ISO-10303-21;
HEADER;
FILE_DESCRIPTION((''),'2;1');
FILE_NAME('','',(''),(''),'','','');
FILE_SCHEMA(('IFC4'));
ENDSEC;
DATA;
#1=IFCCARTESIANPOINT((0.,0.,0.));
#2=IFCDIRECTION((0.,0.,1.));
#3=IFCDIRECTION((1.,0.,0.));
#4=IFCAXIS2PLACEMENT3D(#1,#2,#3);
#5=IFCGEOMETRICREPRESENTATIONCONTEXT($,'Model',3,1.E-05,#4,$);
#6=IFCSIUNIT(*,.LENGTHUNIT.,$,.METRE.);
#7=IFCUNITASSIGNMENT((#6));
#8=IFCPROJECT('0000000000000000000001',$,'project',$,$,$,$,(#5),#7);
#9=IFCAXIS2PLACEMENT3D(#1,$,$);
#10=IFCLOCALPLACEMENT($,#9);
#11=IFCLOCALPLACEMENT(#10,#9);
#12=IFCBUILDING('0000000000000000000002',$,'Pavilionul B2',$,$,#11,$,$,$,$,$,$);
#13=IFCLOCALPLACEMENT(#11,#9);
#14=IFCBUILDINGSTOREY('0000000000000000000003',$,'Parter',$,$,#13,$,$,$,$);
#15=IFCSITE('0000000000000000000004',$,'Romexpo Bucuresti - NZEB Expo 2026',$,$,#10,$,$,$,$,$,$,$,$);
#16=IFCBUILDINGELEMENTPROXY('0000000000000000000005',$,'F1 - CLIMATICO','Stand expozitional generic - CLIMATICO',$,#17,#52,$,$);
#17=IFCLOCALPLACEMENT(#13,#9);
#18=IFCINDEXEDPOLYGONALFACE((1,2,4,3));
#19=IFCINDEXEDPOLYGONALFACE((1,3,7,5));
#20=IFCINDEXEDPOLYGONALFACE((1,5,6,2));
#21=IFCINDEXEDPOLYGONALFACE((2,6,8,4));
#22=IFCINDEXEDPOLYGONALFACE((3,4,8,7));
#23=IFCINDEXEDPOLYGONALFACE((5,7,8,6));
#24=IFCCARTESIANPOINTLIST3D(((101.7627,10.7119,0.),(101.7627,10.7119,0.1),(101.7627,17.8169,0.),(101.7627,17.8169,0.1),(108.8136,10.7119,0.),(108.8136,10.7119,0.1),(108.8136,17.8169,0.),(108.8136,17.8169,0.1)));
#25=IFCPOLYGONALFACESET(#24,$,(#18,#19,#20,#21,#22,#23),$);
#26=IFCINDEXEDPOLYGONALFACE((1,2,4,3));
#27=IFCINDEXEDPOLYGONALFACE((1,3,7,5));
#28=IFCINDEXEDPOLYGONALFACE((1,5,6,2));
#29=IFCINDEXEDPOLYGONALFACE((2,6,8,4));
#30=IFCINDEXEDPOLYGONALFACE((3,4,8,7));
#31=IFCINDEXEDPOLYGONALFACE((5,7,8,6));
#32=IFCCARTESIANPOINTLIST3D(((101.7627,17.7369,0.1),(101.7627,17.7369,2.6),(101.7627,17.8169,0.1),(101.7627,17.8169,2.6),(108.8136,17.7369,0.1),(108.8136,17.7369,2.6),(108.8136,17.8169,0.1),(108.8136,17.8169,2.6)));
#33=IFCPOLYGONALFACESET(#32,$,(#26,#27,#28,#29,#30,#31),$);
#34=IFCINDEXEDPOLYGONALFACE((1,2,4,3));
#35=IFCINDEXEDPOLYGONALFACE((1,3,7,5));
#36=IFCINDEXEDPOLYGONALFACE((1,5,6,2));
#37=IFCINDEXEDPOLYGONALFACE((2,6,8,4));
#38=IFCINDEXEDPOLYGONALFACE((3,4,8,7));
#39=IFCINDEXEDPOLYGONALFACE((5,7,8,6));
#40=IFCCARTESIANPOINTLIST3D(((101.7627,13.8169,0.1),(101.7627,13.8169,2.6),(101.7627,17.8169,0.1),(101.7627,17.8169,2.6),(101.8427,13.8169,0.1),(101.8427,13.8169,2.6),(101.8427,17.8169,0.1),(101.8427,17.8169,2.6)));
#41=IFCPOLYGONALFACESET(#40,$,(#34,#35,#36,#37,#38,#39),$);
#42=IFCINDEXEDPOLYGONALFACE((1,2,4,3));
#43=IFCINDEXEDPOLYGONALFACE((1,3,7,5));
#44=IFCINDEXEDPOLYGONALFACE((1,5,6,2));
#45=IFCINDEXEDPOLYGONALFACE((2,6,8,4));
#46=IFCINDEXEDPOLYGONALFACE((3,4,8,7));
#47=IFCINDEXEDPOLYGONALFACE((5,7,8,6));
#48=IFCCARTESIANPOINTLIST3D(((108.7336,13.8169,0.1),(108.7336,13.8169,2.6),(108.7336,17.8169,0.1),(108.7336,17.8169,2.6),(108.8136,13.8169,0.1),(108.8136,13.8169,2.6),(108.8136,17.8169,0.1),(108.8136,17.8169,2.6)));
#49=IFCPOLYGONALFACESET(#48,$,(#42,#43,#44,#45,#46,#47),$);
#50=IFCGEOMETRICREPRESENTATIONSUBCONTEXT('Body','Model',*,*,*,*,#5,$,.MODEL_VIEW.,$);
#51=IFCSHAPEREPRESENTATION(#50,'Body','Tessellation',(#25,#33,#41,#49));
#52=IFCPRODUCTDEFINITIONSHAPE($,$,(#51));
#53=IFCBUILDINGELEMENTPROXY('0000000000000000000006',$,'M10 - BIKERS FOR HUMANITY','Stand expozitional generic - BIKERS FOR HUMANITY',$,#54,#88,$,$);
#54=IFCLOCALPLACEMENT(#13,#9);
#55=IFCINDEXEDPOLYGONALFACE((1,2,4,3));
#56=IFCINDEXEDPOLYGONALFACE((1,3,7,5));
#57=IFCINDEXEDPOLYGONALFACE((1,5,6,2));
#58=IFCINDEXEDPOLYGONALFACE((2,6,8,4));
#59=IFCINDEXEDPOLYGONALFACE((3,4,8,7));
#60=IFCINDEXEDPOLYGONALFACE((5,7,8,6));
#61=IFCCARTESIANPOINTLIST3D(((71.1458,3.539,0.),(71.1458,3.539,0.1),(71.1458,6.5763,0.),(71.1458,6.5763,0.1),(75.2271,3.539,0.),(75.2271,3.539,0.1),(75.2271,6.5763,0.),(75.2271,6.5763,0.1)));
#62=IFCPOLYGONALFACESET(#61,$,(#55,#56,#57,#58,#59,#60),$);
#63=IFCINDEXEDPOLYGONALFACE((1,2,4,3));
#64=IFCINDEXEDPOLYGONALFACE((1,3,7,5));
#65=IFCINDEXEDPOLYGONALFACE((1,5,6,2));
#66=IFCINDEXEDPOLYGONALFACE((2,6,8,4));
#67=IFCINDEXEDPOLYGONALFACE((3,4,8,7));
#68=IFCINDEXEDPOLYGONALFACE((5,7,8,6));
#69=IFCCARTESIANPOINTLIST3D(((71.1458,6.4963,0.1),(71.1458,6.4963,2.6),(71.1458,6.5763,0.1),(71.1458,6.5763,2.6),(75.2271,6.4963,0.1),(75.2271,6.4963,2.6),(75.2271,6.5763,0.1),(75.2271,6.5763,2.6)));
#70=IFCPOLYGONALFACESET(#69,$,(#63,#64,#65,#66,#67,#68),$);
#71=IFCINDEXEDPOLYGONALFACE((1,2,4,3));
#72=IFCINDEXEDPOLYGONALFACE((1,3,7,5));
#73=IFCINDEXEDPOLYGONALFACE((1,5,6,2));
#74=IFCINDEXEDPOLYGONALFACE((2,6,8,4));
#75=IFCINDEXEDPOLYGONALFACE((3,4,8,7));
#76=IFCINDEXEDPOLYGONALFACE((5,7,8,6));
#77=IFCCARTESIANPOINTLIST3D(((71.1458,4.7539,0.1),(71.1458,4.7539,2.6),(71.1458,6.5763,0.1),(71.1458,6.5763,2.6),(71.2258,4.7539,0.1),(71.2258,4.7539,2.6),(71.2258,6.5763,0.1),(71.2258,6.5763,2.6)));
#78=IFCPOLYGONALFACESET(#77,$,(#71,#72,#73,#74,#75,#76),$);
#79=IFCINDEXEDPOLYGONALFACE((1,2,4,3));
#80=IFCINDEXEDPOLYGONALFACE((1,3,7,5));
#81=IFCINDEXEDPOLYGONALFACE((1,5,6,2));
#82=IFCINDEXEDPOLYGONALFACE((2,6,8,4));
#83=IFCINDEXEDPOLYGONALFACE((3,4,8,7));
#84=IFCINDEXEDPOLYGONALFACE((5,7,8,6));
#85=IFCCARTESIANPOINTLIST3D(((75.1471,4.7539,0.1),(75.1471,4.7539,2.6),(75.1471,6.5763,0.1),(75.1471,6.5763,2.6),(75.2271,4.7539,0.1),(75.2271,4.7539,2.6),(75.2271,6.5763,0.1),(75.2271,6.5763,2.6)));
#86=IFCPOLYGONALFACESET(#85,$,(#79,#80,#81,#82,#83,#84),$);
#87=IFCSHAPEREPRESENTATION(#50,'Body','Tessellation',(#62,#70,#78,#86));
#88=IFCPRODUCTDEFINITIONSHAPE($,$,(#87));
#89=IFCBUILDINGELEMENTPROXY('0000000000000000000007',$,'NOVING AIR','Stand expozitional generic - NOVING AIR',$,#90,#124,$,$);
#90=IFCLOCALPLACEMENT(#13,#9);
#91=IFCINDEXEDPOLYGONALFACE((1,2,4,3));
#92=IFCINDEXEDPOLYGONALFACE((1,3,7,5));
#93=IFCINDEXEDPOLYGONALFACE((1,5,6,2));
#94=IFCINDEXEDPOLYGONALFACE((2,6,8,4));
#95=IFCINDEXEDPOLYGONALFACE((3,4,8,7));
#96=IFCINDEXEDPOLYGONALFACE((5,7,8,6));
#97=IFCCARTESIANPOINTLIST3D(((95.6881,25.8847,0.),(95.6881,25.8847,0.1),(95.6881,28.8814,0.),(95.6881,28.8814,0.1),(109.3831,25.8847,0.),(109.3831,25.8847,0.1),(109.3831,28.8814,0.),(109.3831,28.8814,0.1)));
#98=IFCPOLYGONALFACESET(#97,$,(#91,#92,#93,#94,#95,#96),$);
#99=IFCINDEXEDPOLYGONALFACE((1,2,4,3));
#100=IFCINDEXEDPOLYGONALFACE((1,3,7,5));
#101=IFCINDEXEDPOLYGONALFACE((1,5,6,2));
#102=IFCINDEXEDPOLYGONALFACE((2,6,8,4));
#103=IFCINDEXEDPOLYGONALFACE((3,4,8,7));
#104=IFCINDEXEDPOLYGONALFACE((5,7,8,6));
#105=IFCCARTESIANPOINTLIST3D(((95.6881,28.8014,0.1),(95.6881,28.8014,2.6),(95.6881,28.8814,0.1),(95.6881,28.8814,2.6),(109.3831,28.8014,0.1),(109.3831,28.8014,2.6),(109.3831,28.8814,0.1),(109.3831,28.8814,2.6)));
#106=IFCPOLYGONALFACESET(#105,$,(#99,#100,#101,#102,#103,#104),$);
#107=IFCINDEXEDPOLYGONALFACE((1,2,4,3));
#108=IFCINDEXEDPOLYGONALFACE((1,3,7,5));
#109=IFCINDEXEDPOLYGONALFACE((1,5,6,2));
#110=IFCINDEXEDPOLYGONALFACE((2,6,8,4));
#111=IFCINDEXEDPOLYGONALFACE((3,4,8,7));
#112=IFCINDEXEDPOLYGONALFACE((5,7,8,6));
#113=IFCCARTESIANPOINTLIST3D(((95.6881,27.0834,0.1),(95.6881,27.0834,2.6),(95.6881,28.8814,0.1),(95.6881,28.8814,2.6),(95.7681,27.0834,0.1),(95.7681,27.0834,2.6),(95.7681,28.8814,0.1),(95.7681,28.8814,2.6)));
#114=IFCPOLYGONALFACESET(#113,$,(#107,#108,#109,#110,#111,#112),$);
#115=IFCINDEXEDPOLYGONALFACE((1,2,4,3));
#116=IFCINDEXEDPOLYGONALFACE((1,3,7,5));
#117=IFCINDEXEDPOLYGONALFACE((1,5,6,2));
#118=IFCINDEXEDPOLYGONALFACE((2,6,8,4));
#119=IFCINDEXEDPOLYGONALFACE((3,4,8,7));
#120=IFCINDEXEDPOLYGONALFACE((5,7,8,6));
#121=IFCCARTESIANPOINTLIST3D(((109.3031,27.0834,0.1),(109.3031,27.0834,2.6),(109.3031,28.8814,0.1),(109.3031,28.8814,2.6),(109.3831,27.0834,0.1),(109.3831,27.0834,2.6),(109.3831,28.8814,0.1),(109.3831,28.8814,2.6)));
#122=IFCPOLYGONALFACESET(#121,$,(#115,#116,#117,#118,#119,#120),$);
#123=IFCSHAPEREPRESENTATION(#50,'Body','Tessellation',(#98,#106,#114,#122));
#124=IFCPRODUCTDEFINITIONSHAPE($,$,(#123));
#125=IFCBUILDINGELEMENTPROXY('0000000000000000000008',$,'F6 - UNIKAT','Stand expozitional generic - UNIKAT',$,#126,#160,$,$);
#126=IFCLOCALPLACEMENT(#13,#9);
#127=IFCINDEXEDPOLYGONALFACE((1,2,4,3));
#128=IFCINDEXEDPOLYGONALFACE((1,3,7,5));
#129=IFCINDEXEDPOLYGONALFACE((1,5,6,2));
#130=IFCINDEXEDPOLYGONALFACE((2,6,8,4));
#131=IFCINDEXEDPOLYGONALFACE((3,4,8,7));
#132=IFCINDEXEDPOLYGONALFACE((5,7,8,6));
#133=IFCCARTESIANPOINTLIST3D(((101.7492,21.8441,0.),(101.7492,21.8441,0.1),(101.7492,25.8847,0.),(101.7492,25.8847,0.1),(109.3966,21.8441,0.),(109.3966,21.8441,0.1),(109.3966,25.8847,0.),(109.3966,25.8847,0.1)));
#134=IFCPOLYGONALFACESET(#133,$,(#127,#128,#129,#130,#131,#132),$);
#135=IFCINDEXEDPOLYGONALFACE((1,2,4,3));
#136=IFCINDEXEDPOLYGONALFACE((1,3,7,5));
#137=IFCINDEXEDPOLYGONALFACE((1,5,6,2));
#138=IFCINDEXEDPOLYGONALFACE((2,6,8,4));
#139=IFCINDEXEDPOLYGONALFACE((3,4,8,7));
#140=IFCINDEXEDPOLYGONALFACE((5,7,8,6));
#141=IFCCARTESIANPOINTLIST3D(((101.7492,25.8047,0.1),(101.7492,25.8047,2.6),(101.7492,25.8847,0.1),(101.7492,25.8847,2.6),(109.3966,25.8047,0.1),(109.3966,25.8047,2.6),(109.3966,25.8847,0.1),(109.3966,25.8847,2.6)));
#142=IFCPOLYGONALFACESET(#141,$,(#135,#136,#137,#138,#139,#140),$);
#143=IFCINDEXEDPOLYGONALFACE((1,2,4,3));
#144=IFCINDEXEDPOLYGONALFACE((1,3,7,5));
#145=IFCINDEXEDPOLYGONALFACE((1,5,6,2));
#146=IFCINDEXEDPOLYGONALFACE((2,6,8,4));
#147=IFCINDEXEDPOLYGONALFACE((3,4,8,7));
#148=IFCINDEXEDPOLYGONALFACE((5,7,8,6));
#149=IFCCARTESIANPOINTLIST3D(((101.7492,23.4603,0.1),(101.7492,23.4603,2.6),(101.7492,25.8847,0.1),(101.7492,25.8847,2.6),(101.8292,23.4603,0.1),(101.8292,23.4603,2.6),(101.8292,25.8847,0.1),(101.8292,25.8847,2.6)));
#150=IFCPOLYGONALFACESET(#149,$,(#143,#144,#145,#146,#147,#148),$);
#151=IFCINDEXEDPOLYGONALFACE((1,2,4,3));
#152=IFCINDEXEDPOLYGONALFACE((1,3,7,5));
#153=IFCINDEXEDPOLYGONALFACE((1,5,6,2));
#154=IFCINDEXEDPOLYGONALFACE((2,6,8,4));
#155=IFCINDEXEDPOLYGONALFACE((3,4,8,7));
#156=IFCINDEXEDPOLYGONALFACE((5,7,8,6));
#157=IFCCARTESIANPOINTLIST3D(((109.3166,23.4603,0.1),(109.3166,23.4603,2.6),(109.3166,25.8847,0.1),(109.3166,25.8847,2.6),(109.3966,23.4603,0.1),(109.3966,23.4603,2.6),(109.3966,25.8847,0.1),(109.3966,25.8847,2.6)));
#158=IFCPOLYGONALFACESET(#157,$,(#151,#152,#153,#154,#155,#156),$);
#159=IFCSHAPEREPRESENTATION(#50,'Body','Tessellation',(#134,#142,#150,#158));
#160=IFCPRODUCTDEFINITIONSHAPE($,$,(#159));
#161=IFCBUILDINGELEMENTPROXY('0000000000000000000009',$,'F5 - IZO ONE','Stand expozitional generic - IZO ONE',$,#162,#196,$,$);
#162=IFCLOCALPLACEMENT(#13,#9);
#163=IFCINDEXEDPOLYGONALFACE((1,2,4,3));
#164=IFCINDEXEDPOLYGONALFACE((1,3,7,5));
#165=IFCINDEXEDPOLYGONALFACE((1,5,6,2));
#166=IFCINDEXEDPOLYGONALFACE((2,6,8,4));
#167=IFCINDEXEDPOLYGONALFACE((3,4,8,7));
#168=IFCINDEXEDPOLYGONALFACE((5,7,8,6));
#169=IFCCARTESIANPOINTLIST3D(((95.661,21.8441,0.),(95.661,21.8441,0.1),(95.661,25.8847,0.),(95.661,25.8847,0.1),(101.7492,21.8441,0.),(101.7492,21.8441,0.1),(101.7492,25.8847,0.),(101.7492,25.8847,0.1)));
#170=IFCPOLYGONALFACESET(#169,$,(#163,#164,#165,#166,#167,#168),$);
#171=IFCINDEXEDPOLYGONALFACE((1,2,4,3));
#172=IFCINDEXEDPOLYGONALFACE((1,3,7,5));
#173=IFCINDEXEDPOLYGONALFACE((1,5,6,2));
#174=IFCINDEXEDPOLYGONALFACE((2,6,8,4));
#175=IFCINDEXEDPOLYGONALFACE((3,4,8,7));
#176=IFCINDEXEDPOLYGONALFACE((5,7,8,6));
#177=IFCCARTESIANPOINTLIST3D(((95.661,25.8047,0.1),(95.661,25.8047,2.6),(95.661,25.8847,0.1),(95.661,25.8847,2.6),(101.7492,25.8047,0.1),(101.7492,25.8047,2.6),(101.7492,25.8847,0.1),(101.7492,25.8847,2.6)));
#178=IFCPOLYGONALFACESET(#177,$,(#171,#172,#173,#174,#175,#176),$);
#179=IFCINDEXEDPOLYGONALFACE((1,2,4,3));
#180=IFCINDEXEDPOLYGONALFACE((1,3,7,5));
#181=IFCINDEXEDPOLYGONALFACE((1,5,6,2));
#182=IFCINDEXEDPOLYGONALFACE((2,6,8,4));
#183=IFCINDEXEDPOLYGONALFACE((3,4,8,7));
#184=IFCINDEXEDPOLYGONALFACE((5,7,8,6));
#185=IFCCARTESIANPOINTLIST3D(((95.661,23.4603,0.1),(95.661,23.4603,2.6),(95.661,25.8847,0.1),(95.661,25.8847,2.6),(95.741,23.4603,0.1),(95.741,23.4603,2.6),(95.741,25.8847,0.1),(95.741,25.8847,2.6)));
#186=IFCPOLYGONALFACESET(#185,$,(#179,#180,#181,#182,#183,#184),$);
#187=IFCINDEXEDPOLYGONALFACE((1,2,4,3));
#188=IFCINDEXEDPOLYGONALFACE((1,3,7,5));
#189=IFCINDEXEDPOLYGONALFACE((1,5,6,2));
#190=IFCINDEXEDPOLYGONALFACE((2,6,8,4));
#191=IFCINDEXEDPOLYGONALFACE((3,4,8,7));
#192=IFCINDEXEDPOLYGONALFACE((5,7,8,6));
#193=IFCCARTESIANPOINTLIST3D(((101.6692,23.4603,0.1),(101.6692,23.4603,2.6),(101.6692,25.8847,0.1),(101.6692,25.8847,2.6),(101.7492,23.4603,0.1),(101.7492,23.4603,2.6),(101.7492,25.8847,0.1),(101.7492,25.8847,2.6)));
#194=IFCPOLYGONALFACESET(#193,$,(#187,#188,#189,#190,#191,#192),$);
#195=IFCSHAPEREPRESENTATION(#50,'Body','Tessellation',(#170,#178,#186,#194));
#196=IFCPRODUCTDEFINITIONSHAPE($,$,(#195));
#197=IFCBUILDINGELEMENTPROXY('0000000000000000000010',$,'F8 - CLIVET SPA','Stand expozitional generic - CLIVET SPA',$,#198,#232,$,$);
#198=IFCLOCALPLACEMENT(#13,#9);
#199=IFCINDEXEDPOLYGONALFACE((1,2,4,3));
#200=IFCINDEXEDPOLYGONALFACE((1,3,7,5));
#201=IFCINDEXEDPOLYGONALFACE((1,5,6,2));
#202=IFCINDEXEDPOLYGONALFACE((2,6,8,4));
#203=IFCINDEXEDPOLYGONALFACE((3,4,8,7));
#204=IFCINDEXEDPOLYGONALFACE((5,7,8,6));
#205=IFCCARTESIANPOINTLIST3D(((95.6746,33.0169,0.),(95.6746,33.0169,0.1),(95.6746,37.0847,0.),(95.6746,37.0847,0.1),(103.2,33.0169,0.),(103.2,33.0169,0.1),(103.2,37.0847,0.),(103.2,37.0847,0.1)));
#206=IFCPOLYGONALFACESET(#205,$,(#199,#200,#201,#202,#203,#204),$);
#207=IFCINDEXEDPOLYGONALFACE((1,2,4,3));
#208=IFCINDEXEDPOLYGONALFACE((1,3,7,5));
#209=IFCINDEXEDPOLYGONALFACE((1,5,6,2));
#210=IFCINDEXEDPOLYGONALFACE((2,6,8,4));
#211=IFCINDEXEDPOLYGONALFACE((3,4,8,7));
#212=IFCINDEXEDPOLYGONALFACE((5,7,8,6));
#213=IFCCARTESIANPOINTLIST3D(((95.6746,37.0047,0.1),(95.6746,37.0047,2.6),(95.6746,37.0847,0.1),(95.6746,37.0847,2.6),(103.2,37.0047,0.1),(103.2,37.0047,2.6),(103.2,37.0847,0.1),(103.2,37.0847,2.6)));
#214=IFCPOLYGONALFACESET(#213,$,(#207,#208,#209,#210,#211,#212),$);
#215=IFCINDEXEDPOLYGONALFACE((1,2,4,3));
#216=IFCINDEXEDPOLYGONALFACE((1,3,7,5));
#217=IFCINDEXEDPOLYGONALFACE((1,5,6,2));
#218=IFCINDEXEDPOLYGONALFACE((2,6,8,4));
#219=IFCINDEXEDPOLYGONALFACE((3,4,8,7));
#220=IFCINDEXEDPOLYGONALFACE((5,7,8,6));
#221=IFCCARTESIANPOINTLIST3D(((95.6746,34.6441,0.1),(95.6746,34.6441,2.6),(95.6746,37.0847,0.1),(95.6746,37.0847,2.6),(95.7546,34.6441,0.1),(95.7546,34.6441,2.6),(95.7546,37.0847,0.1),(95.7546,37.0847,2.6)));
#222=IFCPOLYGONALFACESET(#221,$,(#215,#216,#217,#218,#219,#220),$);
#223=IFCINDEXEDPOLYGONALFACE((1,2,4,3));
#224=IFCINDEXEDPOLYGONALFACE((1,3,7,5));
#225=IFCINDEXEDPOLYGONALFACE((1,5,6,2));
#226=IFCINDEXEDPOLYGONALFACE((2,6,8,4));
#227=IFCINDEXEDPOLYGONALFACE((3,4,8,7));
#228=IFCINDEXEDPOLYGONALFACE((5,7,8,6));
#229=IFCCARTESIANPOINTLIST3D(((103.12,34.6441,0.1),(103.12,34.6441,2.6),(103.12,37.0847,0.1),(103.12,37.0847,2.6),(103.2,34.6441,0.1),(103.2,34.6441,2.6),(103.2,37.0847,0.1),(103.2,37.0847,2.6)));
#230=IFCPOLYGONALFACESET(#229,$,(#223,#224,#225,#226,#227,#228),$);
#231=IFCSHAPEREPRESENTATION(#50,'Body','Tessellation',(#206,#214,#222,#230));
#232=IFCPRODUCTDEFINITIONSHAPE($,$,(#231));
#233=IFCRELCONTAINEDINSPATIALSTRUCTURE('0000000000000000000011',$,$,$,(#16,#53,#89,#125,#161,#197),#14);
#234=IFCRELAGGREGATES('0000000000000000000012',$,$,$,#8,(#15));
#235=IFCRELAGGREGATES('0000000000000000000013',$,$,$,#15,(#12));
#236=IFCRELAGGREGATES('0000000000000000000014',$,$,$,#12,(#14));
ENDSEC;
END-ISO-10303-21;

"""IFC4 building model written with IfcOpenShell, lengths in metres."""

from ifc_helpers import new_model, si_unit, frame, frame_2d, origin, origin_with_axes, place, context, subcontext, project, spatial, rectangle, extrude, element, save


model = new_model("IFC4")

# Units and contexts
model_context = context("Model", 3, precision=1e-05, world=origin_with_axes())
body_context = subcontext(model_context, "Body", "Model", "MODEL_VIEW")
ifc_project = project(units=[si_unit("LENGTHUNIT", "METRE")], contexts=[model_context])

# Site, building, storey
site_placement = place(None, origin())
site = spatial("IfcSite", under=ifc_project, at=site_placement, Name="Romexpo Bucuresti - NZEB Expo 2026")
building_placement = place(site_placement, origin())
building = spatial("IfcBuilding", under=site, at=building_placement, Name="Pavilionul B2")
storey_placement = place(building_placement, origin())
storey = spatial("IfcBuildingStorey", under=building, at=storey_placement, Name="Parter")

# Building element proxies
proxy_1_placement = place(storey_placement, frame((101.7627, 10.7119, 0.0), z_axis=(0.0, 0.0, 1.0), x_axis=(1.0, 0.0, 0.0)))
element("IfcBuildingElementProxy", 1, at=proxy_1_placement, inside=storey, Name="F1 - CLIMATICO", Description="Stand expozitional generic - CLIMATICO", context=body_context, shape_type="SweptSolid", body=[
    extrude(rectangle(XDim=7.0508, YDim=7.1051, at=frame_2d((3.5254, 3.5525))), origin(), (0.0, 0.0, 1.0), 0.1),
    extrude(rectangle(XDim=7.0508, YDim=0.08, at=frame_2d((3.5254, 7.0651))), frame((0.0, 0.0, 0.1)), (0.0, 0.0, 1.0), 2.5),
    extrude(rectangle(XDim=0.08, YDim=4.0, at=frame_2d((0.04, 5.1051))), frame((0.0, 0.0, 0.1)), (0.0, 0.0, 1.0), 2.5),
    extrude(rectangle(XDim=0.08, YDim=4.0, at=frame_2d((7.0108, 5.1051))), frame((0.0, 0.0, 0.1)), (0.0, 0.0, 1.0), 2.5),
])
proxy_2_placement = place(storey_placement, frame((71.1458, 3.539, 0.0), z_axis=(0.0, 0.0, 1.0), x_axis=(1.0, 0.0, 0.0)))
element("IfcBuildingElementProxy", 2, at=proxy_2_placement, inside=storey, Name="M10 - BIKERS FOR HUMANITY", Description="Stand expozitional generic - BIKERS FOR HUMANITY", context=body_context, shape_type="SweptSolid", body=[
    extrude(rectangle(XDim=4.0814, YDim=3.0373, at=frame_2d((2.0407, 1.5186))), origin(), (0.0, 0.0, 1.0), 0.1),
    extrude(rectangle(XDim=4.0814, YDim=0.08, at=frame_2d((2.0407, 2.9973))), frame((0.0, 0.0, 0.1)), (0.0, 0.0, 1.0), 2.5),
    extrude(rectangle(XDim=0.08, YDim=1.8224, at=frame_2d((0.04, 2.1261))), frame((0.0, 0.0, 0.1)), (0.0, 0.0, 1.0), 2.5),
    extrude(rectangle(XDim=0.08, YDim=1.8224, at=frame_2d((4.0414, 2.1261))), frame((0.0, 0.0, 0.1)), (0.0, 0.0, 1.0), 2.5),
])
proxy_3_placement = place(storey_placement, frame((95.6881, 25.8847, 0.0), z_axis=(0.0, 0.0, 1.0), x_axis=(1.0, 0.0, 0.0)))
element("IfcBuildingElementProxy", 3, at=proxy_3_placement, inside=storey, Name="NOVING AIR", Description="Stand expozitional generic - NOVING AIR", context=body_context, shape_type="SweptSolid", body=[
    extrude(rectangle(XDim=13.6949, YDim=2.9966, at=frame_2d((6.8475, 1.4983))), origin(), (0.0, 0.0, 1.0), 0.1),
    extrude(rectangle(XDim=13.6949, YDim=0.08, at=frame_2d((6.8475, 2.9566))), frame((0.0, 0.0, 0.1)), (0.0, 0.0, 1.0), 2.5),
    extrude(rectangle(XDim=0.08, YDim=1.798, at=frame_2d((0.04, 2.0976))), frame((0.0, 0.0, 0.1)), (0.0, 0.0, 1.0), 2.5),
    extrude(rectangle(XDim=0.08, YDim=1.798, at=frame_2d((13.6549, 2.0976))), frame((0.0, 0.0, 0.1)), (0.0, 0.0, 1.0), 2.5),
])
proxy_4_placement = place(storey_placement, frame((101.7492, 21.8441, 0.0), z_axis=(0.0, 0.0, 1.0), x_axis=(1.0, 0.0, 0.0)))
element("IfcBuildingElementProxy", 4, at=proxy_4_placement, inside=storey, Name="F6 - UNIKAT", Description="Stand expozitional generic - UNIKAT", context=body_context, shape_type="SweptSolid", body=[
    extrude(rectangle(XDim=7.6475, YDim=4.0407, at=frame_2d((3.8237, 2.0203))), origin(), (0.0, 0.0, 1.0), 0.1),
    extrude(rectangle(XDim=7.6475, YDim=0.08, at=frame_2d((3.8237, 4.0007))), frame((0.0, 0.0, 0.1)), (0.0, 0.0, 1.0), 2.5),
    extrude(rectangle(XDim=0.08, YDim=2.4244, at=frame_2d((0.04, 2.8285))), frame((0.0, 0.0, 0.1)), (0.0, 0.0, 1.0), 2.5),
    extrude(rectangle(XDim=0.08, YDim=2.4244, at=frame_2d((7.6075, 2.8285))), frame((0.0, 0.0, 0.1)), (0.0, 0.0, 1.0), 2.5),
])
proxy_5_placement = place(storey_placement, frame((95.661, 21.8441, 0.0), z_axis=(0.0, 0.0, 1.0), x_axis=(1.0, 0.0, 0.0)))
element("IfcBuildingElementProxy", 5, at=proxy_5_placement, inside=storey, Name="F5 - IZO ONE", Description="Stand expozitional generic - IZO ONE", context=body_context, shape_type="SweptSolid", body=[
    extrude(rectangle(XDim=6.0881, YDim=4.0407, at=frame_2d((3.0441, 2.0203))), origin(), (0.0, 0.0, 1.0), 0.1),
    extrude(rectangle(XDim=6.0881, YDim=0.08, at=frame_2d((3.0441, 4.0007))), frame((0.0, 0.0, 0.1)), (0.0, 0.0, 1.0), 2.5),
    extrude(rectangle(XDim=0.08, YDim=2.4244, at=frame_2d((0.04, 2.8285))), frame((0.0, 0.0, 0.1)), (0.0, 0.0, 1.0), 2.5),
    extrude(rectangle(XDim=0.08, YDim=2.4244, at=frame_2d((6.0481, 2.8285))), frame((0.0, 0.0, 0.1)), (0.0, 0.0, 1.0), 2.5),
])
proxy_6_placement = place(storey_placement, frame((95.6746, 33.0169, 0.0), z_axis=(0.0, 0.0, 1.0), x_axis=(1.0, 0.0, 0.0)))
element("IfcBuildingElementProxy", 6, at=proxy_6_placement, inside=storey, Name="F8 - CLIVET SPA", Description="Stand expozitional generic - CLIVET SPA", context=body_context, shape_type="SweptSolid", body=[
    extrude(rectangle(XDim=7.5254, YDim=4.0678, at=frame_2d((3.7627, 2.0339))), origin(), (0.0, 0.0, 1.0), 0.1),
    extrude(rectangle(XDim=7.5254, YDim=0.08, at=frame_2d((3.7627, 4.0278))), frame((0.0, 0.0, 0.1)), (0.0, 0.0, 1.0), 2.5),
    extrude(rectangle(XDim=0.08, YDim=2.4407, at=frame_2d((0.04, 2.8475))), frame((0.0, 0.0, 0.1)), (0.0, 0.0, 1.0), 2.5),
    extrude(rectangle(XDim=0.08, YDim=2.4407, at=frame_2d((7.4854, 2.8475))), frame((0.0, 0.0, 0.1)), (0.0, 0.0, 1.0), 2.5),
])

save(model, "model.ifc")
